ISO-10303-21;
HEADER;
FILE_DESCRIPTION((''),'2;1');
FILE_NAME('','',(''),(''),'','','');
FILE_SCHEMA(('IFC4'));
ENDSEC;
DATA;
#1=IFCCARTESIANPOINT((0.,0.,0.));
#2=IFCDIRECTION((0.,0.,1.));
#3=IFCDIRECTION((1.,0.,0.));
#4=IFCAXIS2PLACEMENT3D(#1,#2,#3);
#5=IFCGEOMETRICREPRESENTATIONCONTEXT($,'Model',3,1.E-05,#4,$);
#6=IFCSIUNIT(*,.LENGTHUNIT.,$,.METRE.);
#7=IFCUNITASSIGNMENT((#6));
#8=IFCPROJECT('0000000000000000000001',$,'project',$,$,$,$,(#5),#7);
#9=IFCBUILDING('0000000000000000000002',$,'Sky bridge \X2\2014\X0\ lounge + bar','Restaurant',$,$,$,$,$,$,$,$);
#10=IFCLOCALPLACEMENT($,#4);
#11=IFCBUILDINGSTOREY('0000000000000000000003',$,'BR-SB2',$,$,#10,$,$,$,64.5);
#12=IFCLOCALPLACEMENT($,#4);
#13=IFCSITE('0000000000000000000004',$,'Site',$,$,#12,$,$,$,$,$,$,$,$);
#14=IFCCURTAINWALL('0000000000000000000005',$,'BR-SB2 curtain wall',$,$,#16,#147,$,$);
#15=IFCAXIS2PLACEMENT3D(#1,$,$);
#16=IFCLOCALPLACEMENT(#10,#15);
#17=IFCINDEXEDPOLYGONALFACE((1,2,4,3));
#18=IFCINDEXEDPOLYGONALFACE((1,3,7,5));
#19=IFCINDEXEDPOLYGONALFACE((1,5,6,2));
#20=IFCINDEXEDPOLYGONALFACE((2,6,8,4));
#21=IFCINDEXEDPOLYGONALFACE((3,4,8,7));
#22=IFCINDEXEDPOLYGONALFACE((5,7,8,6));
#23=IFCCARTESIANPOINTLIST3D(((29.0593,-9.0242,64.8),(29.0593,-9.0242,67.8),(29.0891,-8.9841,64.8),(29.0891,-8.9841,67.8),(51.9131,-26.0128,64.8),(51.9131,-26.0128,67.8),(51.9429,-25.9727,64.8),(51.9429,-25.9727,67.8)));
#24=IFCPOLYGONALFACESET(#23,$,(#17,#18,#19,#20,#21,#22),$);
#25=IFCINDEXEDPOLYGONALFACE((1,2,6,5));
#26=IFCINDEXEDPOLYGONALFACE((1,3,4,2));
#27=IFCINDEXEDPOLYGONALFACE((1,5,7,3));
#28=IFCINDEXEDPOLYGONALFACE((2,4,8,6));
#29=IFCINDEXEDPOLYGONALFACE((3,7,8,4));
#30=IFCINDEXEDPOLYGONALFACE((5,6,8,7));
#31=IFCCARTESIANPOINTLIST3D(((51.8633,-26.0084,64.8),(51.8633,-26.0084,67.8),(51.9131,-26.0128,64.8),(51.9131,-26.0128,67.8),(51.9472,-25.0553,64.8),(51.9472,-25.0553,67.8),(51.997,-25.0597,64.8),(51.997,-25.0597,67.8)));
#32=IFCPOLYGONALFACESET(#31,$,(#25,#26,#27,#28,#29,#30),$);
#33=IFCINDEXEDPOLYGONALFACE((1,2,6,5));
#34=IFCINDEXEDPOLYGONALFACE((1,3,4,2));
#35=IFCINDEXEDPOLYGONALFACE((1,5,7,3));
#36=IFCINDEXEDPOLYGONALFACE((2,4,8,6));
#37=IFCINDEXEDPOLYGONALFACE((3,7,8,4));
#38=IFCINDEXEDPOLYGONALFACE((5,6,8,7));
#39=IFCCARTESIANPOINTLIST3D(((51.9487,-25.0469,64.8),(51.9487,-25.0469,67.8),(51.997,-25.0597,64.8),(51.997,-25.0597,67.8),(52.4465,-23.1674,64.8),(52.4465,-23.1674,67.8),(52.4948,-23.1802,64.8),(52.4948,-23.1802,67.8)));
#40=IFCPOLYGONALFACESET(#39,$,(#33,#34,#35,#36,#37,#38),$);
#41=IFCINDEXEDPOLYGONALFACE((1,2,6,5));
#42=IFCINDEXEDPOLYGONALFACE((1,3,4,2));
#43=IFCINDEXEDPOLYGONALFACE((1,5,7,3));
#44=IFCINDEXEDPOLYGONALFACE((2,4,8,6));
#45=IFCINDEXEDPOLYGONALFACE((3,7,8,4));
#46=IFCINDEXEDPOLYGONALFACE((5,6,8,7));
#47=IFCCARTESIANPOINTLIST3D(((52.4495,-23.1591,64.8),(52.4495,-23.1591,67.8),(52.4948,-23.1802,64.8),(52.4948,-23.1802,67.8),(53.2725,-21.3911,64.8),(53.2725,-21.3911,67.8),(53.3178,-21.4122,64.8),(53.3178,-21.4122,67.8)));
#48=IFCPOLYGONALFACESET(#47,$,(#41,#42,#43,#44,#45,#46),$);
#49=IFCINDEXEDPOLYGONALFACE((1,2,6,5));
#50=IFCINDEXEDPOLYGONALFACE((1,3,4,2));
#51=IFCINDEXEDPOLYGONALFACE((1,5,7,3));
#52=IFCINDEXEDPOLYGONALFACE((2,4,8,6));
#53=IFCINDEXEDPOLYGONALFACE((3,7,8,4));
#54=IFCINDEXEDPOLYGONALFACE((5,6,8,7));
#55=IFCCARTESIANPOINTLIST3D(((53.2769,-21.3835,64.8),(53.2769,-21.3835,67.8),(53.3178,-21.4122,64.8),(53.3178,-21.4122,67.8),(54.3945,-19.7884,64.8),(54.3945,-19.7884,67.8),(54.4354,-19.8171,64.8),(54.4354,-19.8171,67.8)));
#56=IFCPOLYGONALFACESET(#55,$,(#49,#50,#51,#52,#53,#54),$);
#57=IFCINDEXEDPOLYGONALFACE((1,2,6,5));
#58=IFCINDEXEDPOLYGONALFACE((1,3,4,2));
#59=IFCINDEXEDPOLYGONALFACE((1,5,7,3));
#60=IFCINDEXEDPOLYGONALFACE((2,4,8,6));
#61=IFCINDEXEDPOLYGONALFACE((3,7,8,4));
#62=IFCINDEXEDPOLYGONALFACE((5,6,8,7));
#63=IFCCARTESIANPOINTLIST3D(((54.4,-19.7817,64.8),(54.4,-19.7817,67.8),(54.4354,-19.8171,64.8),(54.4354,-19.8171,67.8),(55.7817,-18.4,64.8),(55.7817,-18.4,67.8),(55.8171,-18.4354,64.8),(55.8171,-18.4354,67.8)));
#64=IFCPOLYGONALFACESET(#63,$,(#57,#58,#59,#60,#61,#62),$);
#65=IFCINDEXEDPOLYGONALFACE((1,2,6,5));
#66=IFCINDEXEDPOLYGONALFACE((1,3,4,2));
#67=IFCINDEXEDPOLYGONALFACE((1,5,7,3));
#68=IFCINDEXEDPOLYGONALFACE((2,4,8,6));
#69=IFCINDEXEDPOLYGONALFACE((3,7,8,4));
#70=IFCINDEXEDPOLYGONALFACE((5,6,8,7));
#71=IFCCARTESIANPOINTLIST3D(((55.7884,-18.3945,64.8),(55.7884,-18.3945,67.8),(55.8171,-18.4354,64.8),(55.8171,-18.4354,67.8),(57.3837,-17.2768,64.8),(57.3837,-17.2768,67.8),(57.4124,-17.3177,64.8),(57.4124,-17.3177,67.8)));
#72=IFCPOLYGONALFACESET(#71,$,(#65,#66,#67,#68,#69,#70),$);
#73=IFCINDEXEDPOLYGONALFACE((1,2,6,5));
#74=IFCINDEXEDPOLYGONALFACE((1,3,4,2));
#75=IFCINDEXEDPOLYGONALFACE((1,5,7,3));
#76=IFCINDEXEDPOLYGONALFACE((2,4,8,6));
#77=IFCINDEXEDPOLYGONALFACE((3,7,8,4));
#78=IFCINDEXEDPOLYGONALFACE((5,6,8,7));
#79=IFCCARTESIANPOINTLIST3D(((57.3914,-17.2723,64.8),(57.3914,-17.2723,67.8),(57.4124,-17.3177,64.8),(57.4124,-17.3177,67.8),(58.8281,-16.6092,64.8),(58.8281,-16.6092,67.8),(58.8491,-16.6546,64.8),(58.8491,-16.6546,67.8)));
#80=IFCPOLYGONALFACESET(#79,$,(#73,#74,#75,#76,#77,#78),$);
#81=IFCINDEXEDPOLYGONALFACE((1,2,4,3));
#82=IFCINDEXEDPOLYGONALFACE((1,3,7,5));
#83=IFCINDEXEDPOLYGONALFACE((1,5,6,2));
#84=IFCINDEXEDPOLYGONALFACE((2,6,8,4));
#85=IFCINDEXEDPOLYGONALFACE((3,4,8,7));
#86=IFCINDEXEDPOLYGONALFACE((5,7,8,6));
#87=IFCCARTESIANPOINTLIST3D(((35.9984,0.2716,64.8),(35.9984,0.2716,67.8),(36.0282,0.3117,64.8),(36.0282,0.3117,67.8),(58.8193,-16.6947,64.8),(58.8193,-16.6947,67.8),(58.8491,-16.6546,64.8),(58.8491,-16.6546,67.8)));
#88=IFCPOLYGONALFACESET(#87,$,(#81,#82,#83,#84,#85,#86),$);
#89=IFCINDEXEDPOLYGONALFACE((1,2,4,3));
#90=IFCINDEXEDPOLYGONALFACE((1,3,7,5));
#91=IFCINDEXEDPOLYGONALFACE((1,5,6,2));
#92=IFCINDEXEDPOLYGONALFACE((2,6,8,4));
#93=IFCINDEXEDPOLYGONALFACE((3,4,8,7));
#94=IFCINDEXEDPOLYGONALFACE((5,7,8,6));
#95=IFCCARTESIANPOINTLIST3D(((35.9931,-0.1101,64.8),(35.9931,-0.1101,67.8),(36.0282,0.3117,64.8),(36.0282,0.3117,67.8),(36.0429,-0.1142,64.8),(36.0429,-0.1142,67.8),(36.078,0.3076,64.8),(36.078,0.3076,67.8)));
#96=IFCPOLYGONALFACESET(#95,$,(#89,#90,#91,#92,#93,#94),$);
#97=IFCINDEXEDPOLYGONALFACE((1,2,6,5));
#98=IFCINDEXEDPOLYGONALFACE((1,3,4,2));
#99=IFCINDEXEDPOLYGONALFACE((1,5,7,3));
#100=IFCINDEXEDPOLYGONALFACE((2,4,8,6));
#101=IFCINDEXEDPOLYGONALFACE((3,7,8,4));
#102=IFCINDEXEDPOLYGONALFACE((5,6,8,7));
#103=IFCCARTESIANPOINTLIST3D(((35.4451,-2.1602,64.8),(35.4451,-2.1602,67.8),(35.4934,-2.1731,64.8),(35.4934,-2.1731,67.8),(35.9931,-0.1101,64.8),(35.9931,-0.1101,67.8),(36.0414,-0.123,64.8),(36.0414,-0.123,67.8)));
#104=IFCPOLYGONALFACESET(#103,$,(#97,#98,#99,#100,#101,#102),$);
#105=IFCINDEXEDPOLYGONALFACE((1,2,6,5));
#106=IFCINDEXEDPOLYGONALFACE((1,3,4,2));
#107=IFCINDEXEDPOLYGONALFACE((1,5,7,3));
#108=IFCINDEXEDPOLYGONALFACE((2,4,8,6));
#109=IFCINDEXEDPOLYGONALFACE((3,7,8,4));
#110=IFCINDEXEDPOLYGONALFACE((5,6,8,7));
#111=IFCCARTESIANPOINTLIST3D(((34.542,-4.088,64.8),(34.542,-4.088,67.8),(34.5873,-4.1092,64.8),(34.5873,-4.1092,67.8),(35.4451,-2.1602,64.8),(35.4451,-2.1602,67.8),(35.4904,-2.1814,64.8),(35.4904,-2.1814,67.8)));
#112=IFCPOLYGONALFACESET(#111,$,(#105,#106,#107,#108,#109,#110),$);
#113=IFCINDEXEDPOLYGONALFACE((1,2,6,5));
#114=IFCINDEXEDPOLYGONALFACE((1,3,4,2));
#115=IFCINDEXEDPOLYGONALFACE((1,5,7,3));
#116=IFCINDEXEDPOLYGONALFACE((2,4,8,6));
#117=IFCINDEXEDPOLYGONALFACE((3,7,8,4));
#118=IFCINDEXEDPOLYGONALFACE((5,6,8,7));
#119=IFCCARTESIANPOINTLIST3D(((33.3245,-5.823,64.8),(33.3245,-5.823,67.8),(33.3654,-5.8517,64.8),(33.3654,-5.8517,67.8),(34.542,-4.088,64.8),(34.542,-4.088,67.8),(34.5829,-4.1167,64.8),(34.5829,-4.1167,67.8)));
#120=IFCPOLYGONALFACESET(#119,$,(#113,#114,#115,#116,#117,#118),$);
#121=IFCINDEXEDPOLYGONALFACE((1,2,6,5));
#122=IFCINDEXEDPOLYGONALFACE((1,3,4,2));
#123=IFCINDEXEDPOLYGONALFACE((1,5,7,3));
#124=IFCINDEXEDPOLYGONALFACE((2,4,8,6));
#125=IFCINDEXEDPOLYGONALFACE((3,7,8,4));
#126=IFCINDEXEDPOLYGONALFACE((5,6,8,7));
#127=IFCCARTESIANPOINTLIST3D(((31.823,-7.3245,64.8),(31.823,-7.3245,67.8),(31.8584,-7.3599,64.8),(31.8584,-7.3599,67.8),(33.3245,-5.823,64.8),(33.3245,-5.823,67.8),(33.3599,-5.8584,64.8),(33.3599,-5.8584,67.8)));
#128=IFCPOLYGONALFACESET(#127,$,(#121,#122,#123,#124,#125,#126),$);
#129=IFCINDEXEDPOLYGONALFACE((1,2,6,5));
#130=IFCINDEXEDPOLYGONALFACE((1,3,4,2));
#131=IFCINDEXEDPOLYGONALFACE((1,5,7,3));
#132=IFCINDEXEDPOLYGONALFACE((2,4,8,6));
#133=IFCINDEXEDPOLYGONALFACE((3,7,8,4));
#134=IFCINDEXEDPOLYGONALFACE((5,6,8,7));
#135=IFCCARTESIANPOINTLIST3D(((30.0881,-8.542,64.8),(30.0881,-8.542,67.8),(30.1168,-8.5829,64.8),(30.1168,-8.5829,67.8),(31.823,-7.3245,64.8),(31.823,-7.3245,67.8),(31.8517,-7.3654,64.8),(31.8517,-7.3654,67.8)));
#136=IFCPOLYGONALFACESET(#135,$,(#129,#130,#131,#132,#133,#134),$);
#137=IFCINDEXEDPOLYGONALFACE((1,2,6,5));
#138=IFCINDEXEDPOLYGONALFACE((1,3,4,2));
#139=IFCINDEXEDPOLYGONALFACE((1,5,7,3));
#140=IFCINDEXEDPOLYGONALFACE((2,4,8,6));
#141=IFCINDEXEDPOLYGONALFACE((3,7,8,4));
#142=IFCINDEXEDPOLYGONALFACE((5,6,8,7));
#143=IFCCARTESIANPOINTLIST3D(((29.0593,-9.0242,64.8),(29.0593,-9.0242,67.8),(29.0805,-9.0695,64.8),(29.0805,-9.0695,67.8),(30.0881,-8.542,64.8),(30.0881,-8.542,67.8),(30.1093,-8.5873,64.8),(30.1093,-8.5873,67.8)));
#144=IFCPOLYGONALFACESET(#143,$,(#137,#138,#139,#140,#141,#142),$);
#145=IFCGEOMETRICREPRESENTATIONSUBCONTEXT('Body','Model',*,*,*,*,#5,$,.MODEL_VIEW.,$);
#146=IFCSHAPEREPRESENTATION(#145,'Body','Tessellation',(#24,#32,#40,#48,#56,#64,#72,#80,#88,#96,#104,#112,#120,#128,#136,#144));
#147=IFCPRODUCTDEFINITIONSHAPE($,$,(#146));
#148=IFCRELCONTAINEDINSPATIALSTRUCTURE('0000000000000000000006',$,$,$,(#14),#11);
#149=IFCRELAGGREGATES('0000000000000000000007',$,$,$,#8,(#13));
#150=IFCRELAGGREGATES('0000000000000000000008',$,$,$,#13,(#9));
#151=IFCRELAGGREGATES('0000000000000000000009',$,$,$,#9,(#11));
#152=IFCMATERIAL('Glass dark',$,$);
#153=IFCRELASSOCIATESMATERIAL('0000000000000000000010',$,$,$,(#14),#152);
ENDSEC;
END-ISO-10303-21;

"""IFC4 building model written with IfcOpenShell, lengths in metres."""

from ifc_helpers import new_model, si_unit, frame, origin_with_axes, place, context, subcontext, project, spatial, polyline, outline, extrude, material, element, save


model = new_model("IFC4")

# Units and contexts
model_context = context("Model", 3, precision=1e-05, world=origin_with_axes())
body_context = subcontext(model_context, "Body", "Model", "MODEL_VIEW")
ifc_project = project(units=[si_unit("LENGTHUNIT", "METRE")], contexts=[model_context])

# Site, building, storey
site_placement = place(None, origin_with_axes())
site = spatial("IfcSite", under=ifc_project, at=site_placement, Name="Site")
building = spatial("IfcBuilding", under=site, Name="Sky bridge — lounge + bar", Description="Restaurant")
storey_placement = place(None, origin_with_axes())
storey = spatial("IfcBuildingStorey", under=building, at=storey_placement, Name="BR-SB2", Elevation=64.5)

# Curtain wall
ifc_material_1 = material(Name="Glass dark")
curtain_wall_placement = place(storey_placement, origin_with_axes())
element("IfcCurtainWall", 1, at=curtain_wall_placement, inside=storey, material=ifc_material_1, Name="BR-SB2 curtain wall", context=body_context, shape_type="SweptSolid", body=[
    extrude(outline(polyline([(29.0593, -9.0242), (51.9131, -26.0128), (51.9429, -25.9727), (29.0891, -8.9841), (29.0593, -9.0242)])), frame((0.0, 0.0, 64.8), z_axis=(0.0, 0.0, 1.0), x_axis=(1.0, 0.0, 0.0)), (0.0, 0.0, 1.0), 3.0),
    extrude(outline(polyline([(51.9131, -26.0128), (51.997, -25.0597), (51.9472, -25.0553), (51.8633, -26.0084), (51.9131, -26.0128)])), frame((0.0, 0.0, 64.8), z_axis=(0.0, 0.0, 1.0), x_axis=(1.0, 0.0, 0.0)), (0.0, 0.0, 1.0), 3.0),
    extrude(outline(polyline([(51.997, -25.0597), (52.4948, -23.1802), (52.4465, -23.1674), (51.9487, -25.0469), (51.997, -25.0597)])), frame((0.0, 0.0, 64.8), z_axis=(0.0, 0.0, 1.0), x_axis=(1.0, 0.0, 0.0)), (0.0, 0.0, 1.0), 3.0),
    extrude(outline(polyline([(52.4948, -23.1802), (53.3178, -21.4122), (53.2725, -21.3911), (52.4495, -23.1591), (52.4948, -23.1802)])), frame((0.0, 0.0, 64.8), z_axis=(0.0, 0.0, 1.0), x_axis=(1.0, 0.0, 0.0)), (0.0, 0.0, 1.0), 3.0),
    extrude(outline(polyline([(53.3178, -21.4122), (54.4354, -19.8171), (54.3945, -19.7884), (53.2769, -21.3835), (53.3178, -21.4122)])), frame((0.0, 0.0, 64.8), z_axis=(0.0, 0.0, 1.0), x_axis=(1.0, 0.0, 0.0)), (0.0, 0.0, 1.0), 3.0),
    extrude(outline(polyline([(54.4354, -19.8171), (55.8171, -18.4354), (55.7817, -18.4), (54.4, -19.7817), (54.4354, -19.8171)])), frame((0.0, 0.0, 64.8), z_axis=(0.0, 0.0, 1.0), x_axis=(1.0, 0.0, 0.0)), (0.0, 0.0, 1.0), 3.0),
    extrude(outline(polyline([(55.8171, -18.4354), (57.4124, -17.3177), (57.3837, -17.2768), (55.7884, -18.3945), (55.8171, -18.4354)])), frame((0.0, 0.0, 64.8), z_axis=(0.0, 0.0, 1.0), x_axis=(1.0, 0.0, 0.0)), (0.0, 0.0, 1.0), 3.0),
    extrude(outline(polyline([(57.4124, -17.3177), (58.8491, -16.6546), (58.8281, -16.6092), (57.3914, -17.2723), (57.4124, -17.3177)])), frame((0.0, 0.0, 64.8), z_axis=(0.0, 0.0, 1.0), x_axis=(1.0, 0.0, 0.0)), (0.0, 0.0, 1.0), 3.0),
    extrude(outline(polyline([(58.8491, -16.6546), (36.0282, 0.3117), (35.9984, 0.2716), (58.8193, -16.6947), (58.8491, -16.6546)])), frame((0.0, 0.0, 64.8), z_axis=(0.0, 0.0, 1.0), x_axis=(1.0, 0.0, 0.0)), (0.0, 0.0, 1.0), 3.0),
    extrude(outline(polyline([(36.0282, 0.3117), (35.9931, -0.1101), (36.0429, -0.1142), (36.078, 0.3076), (36.0282, 0.3117)])), frame((0.0, 0.0, 64.8), z_axis=(0.0, 0.0, 1.0), x_axis=(1.0, 0.0, 0.0)), (0.0, 0.0, 1.0), 3.0),
    extrude(outline(polyline([(35.9931, -0.1101), (35.4451, -2.1602), (35.4934, -2.1731), (36.0414, -0.123), (35.9931, -0.1101)])), frame((0.0, 0.0, 64.8), z_axis=(0.0, 0.0, 1.0), x_axis=(1.0, 0.0, 0.0)), (0.0, 0.0, 1.0), 3.0),
    extrude(outline(polyline([(35.4451, -2.1602), (34.542, -4.088), (34.5873, -4.1092), (35.4904, -2.1814), (35.4451, -2.1602)])), frame((0.0, 0.0, 64.8), z_axis=(0.0, 0.0, 1.0), x_axis=(1.0, 0.0, 0.0)), (0.0, 0.0, 1.0), 3.0),
    extrude(outline(polyline([(34.542, -4.088), (33.3245, -5.823), (33.3654, -5.8517), (34.5829, -4.1167), (34.542, -4.088)])), frame((0.0, 0.0, 64.8), z_axis=(0.0, 0.0, 1.0), x_axis=(1.0, 0.0, 0.0)), (0.0, 0.0, 1.0), 3.0),
    extrude(outline(polyline([(33.3245, -5.823), (31.823, -7.3245), (31.8584, -7.3599), (33.3599, -5.8584), (33.3245, -5.823)])), frame((0.0, 0.0, 64.8), z_axis=(0.0, 0.0, 1.0), x_axis=(1.0, 0.0, 0.0)), (0.0, 0.0, 1.0), 3.0),
    extrude(outline(polyline([(31.823, -7.3245), (30.0881, -8.542), (30.1168, -8.5829), (31.8517, -7.3654), (31.823, -7.3245)])), frame((0.0, 0.0, 64.8), z_axis=(0.0, 0.0, 1.0), x_axis=(1.0, 0.0, 0.0)), (0.0, 0.0, 1.0), 3.0),
    extrude(outline(polyline([(30.0881, -8.542), (29.0593, -9.0242), (29.0805, -9.0695), (30.1093, -8.5873), (30.0881, -8.542)])), frame((0.0, 0.0, 64.8), z_axis=(0.0, 0.0, 1.0), x_axis=(1.0, 0.0, 0.0)), (0.0, 0.0, 1.0), 3.0),
])

save(model, "model.ifc")
